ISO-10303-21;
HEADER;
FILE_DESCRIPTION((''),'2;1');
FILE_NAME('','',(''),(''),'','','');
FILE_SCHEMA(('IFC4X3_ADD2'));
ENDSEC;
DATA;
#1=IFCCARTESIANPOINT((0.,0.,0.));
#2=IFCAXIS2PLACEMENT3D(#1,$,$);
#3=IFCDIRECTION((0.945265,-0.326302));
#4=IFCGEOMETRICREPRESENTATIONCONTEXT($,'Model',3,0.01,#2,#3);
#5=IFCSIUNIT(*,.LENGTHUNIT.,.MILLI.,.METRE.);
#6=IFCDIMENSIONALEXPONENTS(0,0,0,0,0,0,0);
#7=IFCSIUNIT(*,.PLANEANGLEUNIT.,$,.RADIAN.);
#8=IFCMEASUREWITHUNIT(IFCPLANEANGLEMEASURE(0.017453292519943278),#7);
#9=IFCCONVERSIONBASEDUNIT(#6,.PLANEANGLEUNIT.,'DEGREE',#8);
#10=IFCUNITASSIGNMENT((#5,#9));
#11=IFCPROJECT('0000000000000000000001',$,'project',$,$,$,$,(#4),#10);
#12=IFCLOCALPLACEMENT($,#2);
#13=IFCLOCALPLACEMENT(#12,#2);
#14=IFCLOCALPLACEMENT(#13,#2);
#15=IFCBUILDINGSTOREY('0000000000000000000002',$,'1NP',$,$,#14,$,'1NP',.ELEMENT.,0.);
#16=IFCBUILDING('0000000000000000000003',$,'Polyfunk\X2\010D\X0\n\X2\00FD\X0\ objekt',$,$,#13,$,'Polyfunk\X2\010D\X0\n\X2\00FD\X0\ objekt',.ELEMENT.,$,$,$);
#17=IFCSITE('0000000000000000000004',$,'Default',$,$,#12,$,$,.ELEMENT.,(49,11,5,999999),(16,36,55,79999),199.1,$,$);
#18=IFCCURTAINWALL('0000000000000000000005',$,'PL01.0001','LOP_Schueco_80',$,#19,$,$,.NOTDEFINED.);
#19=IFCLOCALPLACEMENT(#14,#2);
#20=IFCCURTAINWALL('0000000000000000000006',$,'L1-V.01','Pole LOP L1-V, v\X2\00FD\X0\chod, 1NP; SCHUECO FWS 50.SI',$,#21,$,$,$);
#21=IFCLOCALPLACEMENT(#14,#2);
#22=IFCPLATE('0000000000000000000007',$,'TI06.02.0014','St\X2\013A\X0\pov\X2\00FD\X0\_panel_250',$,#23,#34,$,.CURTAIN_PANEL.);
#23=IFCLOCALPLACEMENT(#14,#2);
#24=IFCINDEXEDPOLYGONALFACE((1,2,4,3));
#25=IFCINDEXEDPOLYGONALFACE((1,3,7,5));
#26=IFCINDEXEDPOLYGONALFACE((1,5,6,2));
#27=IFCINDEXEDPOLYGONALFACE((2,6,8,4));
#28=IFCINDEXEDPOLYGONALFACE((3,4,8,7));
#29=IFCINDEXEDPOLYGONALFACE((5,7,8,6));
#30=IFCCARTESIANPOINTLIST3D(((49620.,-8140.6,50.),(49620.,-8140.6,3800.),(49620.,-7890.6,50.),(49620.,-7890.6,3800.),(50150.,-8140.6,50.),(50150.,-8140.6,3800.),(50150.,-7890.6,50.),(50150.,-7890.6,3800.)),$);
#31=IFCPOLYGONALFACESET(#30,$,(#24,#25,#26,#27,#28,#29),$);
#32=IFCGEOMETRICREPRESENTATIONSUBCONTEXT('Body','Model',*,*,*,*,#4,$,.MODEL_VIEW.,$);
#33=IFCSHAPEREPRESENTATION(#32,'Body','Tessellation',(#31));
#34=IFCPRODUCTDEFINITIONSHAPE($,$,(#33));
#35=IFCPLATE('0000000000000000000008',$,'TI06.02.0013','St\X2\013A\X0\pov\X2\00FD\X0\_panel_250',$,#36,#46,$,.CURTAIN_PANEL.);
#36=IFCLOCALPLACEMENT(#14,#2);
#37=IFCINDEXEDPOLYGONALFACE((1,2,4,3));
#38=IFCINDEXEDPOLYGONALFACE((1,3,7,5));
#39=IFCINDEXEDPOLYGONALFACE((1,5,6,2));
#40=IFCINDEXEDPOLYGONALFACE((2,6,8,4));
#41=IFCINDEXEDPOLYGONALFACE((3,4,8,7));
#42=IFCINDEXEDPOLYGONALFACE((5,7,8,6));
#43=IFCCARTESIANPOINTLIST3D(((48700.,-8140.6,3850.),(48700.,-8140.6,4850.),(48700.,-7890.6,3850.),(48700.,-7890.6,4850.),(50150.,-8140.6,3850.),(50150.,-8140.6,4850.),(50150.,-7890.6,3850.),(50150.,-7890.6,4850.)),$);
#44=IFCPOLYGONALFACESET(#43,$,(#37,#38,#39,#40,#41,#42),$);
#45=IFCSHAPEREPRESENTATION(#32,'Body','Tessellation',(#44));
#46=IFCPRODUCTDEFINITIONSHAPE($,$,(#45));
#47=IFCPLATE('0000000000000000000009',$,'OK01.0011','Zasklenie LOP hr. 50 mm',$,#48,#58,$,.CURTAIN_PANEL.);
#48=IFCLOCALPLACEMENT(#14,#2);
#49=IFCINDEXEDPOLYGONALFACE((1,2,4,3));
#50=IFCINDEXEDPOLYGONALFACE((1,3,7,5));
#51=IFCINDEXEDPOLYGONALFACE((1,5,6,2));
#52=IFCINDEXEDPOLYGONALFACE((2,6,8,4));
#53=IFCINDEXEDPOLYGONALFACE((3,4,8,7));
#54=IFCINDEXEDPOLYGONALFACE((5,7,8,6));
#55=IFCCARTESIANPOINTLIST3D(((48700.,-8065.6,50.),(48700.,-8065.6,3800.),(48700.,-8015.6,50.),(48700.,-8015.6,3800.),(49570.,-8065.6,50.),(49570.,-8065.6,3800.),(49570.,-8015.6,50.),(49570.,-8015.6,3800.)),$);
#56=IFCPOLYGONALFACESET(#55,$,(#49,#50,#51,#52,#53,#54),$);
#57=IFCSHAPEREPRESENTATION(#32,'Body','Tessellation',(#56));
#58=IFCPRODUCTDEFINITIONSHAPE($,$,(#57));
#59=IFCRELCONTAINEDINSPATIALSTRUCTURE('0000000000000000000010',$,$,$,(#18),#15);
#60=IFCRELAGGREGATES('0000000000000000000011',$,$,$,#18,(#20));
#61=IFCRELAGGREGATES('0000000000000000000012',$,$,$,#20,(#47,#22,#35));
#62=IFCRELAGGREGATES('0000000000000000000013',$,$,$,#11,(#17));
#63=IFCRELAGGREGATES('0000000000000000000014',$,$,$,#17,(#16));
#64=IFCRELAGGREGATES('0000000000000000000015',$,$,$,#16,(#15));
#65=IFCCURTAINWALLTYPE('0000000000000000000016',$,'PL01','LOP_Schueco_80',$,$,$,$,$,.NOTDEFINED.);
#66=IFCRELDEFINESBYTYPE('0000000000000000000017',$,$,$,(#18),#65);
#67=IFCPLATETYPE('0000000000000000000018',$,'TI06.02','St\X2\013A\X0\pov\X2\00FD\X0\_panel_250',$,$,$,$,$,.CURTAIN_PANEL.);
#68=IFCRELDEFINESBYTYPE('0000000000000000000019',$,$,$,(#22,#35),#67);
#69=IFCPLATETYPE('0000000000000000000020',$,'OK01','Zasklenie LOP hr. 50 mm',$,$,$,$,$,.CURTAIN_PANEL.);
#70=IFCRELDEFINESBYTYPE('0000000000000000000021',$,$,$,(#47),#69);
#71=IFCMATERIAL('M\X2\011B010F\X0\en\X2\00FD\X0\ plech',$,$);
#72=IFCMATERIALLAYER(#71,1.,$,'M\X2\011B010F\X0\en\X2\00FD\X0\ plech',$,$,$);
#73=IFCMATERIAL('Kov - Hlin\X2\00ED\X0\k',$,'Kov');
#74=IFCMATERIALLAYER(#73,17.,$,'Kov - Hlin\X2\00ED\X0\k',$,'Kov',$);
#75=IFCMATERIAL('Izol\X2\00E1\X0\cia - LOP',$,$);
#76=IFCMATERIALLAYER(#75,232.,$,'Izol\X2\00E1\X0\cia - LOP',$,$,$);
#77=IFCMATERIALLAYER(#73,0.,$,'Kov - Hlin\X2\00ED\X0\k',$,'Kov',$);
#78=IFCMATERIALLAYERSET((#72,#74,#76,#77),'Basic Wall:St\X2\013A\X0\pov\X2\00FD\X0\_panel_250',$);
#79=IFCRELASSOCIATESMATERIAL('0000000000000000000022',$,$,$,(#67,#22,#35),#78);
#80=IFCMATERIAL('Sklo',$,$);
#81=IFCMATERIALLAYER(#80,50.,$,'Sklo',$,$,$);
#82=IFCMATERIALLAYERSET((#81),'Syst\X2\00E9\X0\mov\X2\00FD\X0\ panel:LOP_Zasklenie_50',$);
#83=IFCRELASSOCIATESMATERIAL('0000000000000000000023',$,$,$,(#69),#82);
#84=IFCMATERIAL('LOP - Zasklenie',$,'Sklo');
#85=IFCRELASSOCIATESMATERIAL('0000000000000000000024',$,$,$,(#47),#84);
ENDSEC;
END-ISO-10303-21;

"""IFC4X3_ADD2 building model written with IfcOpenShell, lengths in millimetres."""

from ifc_helpers import new_model, entity, si_unit, converted_unit, direction, frame, frame_2d, origin, place, context, subcontext, project, spatial, rectangle, extrude, source, transform, mapped, material, layer, layer_set, layer_usage, type_object, type_shapes, element, aggregate, save


model = new_model("IFC4X3_ADD2")

# Units and contexts
model_context = context("Model", 3, precision=0.01, world=origin(), true_north=direction((0.945265, -0.326302)))
body_context = subcontext(model_context, "Body", "Model", "MODEL_VIEW")
ifc_project = project(units=[si_unit("LENGTHUNIT", "METRE", prefix="MILLI"), converted_unit("PLANEANGLEUNIT", "DEGREE", entity("IfcPlaneAngleMeasure", 0.017453292519943278), si_unit("PLANEANGLEUNIT", "RADIAN"), dimensions=[0, 0, 0, 0, 0, 0, 0])], contexts=[model_context])

# Site, building, storey
site_placement = place(None, origin())
site = spatial("IfcSite", under=ifc_project, at=site_placement, Name="Default", CompositionType="ELEMENT", RefLatitude=(49, 11, 5, 999999), RefLongitude=(16, 36, 55, 79999), RefElevation=199.1)
building_placement = place(site_placement, origin())
building = spatial("IfcBuilding", under=site, at=building_placement, Name="Polyfunkčný objekt", LongName="Polyfunkčný objekt", CompositionType="ELEMENT")
storey_placement = place(building_placement, origin())
storey = spatial("IfcBuildingStorey", under=building, at=storey_placement, Name="1NP", LongName="1NP", CompositionType="ELEMENT", Elevation=0.0)

# Curtain walls, plates
curtain_wall_type = type_object("IfcCurtainWallType", Name="PL01", Description="LOP_Schueco_80", PredefinedType="NOTDEFINED")
curtain_wall_1_placement = place(storey_placement, origin())
curtain_wall_1 = element("IfcCurtainWall", 1, at=curtain_wall_1_placement, inside=storey, type_object=curtain_wall_type, Name="PL01.0001", Description="LOP_Schueco_80", PredefinedType="NOTDEFINED")
curtain_wall_2 = element("IfcCurtainWall", 2, Name="L1-V.01", Description="Pole LOP L1-V, východ, 1NP; SCHUECO FWS 50.SI")
aggregate(curtain_wall_1, [curtain_wall_2])
ifc_material_1 = material(Name="Měďený plech")
ifc_layer_1 = layer(ifc_material_1, 1.0, Name="Měďený plech")
ifc_material_2 = material(Name="Kov - Hliník", Category="Kov")
ifc_layer_2 = layer(ifc_material_2, 17.0, Name="Kov - Hliník", Category="Kov")
ifc_material_3 = material(Name="Izolácia - LOP")
ifc_layer_3 = layer(ifc_material_3, 232.0, Name="Izolácia - LOP")
ifc_layer_4 = layer(ifc_material_2, 0.0, Name="Kov - Hliník", Category="Kov")
ifc_layer_set_1 = layer_set([ifc_layer_1, ifc_layer_2, ifc_layer_3, ifc_layer_4], Name="Basic Wall:Stĺpový_panel_250")
ifc_layer_usage_1 = layer_usage(ifc_layer_set_1, "AXIS2", "POSITIVE", -125.0)
plate_type_1 = type_object("IfcPlateType", Name="TI06.02", Description="Stĺpový_panel_250", PredefinedType="CURTAIN_PANEL", material=ifc_layer_set_1)
plate_1_placement = place(storey_placement, frame((49620.0, -8015.6, 50.0)))
plate_1 = element("IfcPlate", 3, at=plate_1_placement, type_object=plate_type_1, material=ifc_layer_usage_1, Name="TI06.02.0014", Description="Stĺpový_panel_250", PredefinedType="CURTAIN_PANEL", context=body_context, shape_type="SweptSolid", body=[
    extrude(rectangle(XDim=250.0, YDim=530.0, at=frame_2d((0.0, 0.0), x_axis=(1.0, 0.0))), frame((265.0, 0.0, 0.0), z_axis=(0.0, 0.0, 1.0), x_axis=(0.0, 1.0, 0.0)), (0.0, 0.0, 1.0), 3750.0),
])
ifc_layer_usage_2 = layer_usage(ifc_layer_set_1, "AXIS2", "POSITIVE", -125.0)
plate_2_placement = place(storey_placement, frame((48700.0, -8015.6, 3850.0)))
plate_2 = element("IfcPlate", 4, at=plate_2_placement, type_object=plate_type_1, material=ifc_layer_usage_2, Name="TI06.02.0013", Description="Stĺpový_panel_250", PredefinedType="CURTAIN_PANEL", context=body_context, shape_type="SweptSolid", body=[
    extrude(rectangle(XDim=250.0, YDim=1450.0, at=frame_2d((0.0, 0.0), x_axis=(1.0, 0.0))), frame((725.0, 0.0, 0.0), z_axis=(0.0, 0.0, 1.0), x_axis=(0.0, 1.0, 0.0)), (0.0, 0.0, 1.0), 1000.0),
])
ifc_material_4 = material(Name="LOP - Zasklenie", Category="Sklo")
ifc_material_5 = material(Name="Sklo")
ifc_layer_5 = layer(ifc_material_5, 50.0, Name="Sklo")
ifc_layer_set_2 = layer_set([ifc_layer_5], Name="Systémový panel:LOP_Zasklenie_50")
plate_type_2 = type_object("IfcPlateType", Name="OK01", Description="Zasklenie LOP hr. 50 mm", PredefinedType="CURTAIN_PANEL", material=ifc_layer_set_2)
shared_shape_1 = source(origin(), body_context, "Body", "SweptSolid", [
    extrude(rectangle(XDim=3750.0, YDim=870.0, at=frame_2d((-331.2, 0.0), x_axis=(1.0, 0.0))), frame((0.0, -50.0, 2206.2), z_axis=(0.0, 1.0, 0.0), x_axis=(0.0, 0.0, 1.0)), (0.0, 0.0, 1.0), 50.0),
])
type_shapes(plate_type_2, [shared_shape_1])
plate_3_placement = place(curtain_wall_1_placement, frame((49135.0, -8015.6, 50.0)))
plate_3 = element("IfcPlate", 5, at=plate_3_placement, type_object=plate_type_2, material=ifc_material_4, Name="OK01.0011", Description="Zasklenie LOP hr. 50 mm", PredefinedType="CURTAIN_PANEL", context=body_context, shape_type="MappedRepresentation", body=[
    mapped(shared_shape_1, transform((0.0, 0.0, 0.0), scale=1.0)),
])
aggregate(curtain_wall_2, [plate_3, plate_1, plate_2])

save(model, "model.ifc")
